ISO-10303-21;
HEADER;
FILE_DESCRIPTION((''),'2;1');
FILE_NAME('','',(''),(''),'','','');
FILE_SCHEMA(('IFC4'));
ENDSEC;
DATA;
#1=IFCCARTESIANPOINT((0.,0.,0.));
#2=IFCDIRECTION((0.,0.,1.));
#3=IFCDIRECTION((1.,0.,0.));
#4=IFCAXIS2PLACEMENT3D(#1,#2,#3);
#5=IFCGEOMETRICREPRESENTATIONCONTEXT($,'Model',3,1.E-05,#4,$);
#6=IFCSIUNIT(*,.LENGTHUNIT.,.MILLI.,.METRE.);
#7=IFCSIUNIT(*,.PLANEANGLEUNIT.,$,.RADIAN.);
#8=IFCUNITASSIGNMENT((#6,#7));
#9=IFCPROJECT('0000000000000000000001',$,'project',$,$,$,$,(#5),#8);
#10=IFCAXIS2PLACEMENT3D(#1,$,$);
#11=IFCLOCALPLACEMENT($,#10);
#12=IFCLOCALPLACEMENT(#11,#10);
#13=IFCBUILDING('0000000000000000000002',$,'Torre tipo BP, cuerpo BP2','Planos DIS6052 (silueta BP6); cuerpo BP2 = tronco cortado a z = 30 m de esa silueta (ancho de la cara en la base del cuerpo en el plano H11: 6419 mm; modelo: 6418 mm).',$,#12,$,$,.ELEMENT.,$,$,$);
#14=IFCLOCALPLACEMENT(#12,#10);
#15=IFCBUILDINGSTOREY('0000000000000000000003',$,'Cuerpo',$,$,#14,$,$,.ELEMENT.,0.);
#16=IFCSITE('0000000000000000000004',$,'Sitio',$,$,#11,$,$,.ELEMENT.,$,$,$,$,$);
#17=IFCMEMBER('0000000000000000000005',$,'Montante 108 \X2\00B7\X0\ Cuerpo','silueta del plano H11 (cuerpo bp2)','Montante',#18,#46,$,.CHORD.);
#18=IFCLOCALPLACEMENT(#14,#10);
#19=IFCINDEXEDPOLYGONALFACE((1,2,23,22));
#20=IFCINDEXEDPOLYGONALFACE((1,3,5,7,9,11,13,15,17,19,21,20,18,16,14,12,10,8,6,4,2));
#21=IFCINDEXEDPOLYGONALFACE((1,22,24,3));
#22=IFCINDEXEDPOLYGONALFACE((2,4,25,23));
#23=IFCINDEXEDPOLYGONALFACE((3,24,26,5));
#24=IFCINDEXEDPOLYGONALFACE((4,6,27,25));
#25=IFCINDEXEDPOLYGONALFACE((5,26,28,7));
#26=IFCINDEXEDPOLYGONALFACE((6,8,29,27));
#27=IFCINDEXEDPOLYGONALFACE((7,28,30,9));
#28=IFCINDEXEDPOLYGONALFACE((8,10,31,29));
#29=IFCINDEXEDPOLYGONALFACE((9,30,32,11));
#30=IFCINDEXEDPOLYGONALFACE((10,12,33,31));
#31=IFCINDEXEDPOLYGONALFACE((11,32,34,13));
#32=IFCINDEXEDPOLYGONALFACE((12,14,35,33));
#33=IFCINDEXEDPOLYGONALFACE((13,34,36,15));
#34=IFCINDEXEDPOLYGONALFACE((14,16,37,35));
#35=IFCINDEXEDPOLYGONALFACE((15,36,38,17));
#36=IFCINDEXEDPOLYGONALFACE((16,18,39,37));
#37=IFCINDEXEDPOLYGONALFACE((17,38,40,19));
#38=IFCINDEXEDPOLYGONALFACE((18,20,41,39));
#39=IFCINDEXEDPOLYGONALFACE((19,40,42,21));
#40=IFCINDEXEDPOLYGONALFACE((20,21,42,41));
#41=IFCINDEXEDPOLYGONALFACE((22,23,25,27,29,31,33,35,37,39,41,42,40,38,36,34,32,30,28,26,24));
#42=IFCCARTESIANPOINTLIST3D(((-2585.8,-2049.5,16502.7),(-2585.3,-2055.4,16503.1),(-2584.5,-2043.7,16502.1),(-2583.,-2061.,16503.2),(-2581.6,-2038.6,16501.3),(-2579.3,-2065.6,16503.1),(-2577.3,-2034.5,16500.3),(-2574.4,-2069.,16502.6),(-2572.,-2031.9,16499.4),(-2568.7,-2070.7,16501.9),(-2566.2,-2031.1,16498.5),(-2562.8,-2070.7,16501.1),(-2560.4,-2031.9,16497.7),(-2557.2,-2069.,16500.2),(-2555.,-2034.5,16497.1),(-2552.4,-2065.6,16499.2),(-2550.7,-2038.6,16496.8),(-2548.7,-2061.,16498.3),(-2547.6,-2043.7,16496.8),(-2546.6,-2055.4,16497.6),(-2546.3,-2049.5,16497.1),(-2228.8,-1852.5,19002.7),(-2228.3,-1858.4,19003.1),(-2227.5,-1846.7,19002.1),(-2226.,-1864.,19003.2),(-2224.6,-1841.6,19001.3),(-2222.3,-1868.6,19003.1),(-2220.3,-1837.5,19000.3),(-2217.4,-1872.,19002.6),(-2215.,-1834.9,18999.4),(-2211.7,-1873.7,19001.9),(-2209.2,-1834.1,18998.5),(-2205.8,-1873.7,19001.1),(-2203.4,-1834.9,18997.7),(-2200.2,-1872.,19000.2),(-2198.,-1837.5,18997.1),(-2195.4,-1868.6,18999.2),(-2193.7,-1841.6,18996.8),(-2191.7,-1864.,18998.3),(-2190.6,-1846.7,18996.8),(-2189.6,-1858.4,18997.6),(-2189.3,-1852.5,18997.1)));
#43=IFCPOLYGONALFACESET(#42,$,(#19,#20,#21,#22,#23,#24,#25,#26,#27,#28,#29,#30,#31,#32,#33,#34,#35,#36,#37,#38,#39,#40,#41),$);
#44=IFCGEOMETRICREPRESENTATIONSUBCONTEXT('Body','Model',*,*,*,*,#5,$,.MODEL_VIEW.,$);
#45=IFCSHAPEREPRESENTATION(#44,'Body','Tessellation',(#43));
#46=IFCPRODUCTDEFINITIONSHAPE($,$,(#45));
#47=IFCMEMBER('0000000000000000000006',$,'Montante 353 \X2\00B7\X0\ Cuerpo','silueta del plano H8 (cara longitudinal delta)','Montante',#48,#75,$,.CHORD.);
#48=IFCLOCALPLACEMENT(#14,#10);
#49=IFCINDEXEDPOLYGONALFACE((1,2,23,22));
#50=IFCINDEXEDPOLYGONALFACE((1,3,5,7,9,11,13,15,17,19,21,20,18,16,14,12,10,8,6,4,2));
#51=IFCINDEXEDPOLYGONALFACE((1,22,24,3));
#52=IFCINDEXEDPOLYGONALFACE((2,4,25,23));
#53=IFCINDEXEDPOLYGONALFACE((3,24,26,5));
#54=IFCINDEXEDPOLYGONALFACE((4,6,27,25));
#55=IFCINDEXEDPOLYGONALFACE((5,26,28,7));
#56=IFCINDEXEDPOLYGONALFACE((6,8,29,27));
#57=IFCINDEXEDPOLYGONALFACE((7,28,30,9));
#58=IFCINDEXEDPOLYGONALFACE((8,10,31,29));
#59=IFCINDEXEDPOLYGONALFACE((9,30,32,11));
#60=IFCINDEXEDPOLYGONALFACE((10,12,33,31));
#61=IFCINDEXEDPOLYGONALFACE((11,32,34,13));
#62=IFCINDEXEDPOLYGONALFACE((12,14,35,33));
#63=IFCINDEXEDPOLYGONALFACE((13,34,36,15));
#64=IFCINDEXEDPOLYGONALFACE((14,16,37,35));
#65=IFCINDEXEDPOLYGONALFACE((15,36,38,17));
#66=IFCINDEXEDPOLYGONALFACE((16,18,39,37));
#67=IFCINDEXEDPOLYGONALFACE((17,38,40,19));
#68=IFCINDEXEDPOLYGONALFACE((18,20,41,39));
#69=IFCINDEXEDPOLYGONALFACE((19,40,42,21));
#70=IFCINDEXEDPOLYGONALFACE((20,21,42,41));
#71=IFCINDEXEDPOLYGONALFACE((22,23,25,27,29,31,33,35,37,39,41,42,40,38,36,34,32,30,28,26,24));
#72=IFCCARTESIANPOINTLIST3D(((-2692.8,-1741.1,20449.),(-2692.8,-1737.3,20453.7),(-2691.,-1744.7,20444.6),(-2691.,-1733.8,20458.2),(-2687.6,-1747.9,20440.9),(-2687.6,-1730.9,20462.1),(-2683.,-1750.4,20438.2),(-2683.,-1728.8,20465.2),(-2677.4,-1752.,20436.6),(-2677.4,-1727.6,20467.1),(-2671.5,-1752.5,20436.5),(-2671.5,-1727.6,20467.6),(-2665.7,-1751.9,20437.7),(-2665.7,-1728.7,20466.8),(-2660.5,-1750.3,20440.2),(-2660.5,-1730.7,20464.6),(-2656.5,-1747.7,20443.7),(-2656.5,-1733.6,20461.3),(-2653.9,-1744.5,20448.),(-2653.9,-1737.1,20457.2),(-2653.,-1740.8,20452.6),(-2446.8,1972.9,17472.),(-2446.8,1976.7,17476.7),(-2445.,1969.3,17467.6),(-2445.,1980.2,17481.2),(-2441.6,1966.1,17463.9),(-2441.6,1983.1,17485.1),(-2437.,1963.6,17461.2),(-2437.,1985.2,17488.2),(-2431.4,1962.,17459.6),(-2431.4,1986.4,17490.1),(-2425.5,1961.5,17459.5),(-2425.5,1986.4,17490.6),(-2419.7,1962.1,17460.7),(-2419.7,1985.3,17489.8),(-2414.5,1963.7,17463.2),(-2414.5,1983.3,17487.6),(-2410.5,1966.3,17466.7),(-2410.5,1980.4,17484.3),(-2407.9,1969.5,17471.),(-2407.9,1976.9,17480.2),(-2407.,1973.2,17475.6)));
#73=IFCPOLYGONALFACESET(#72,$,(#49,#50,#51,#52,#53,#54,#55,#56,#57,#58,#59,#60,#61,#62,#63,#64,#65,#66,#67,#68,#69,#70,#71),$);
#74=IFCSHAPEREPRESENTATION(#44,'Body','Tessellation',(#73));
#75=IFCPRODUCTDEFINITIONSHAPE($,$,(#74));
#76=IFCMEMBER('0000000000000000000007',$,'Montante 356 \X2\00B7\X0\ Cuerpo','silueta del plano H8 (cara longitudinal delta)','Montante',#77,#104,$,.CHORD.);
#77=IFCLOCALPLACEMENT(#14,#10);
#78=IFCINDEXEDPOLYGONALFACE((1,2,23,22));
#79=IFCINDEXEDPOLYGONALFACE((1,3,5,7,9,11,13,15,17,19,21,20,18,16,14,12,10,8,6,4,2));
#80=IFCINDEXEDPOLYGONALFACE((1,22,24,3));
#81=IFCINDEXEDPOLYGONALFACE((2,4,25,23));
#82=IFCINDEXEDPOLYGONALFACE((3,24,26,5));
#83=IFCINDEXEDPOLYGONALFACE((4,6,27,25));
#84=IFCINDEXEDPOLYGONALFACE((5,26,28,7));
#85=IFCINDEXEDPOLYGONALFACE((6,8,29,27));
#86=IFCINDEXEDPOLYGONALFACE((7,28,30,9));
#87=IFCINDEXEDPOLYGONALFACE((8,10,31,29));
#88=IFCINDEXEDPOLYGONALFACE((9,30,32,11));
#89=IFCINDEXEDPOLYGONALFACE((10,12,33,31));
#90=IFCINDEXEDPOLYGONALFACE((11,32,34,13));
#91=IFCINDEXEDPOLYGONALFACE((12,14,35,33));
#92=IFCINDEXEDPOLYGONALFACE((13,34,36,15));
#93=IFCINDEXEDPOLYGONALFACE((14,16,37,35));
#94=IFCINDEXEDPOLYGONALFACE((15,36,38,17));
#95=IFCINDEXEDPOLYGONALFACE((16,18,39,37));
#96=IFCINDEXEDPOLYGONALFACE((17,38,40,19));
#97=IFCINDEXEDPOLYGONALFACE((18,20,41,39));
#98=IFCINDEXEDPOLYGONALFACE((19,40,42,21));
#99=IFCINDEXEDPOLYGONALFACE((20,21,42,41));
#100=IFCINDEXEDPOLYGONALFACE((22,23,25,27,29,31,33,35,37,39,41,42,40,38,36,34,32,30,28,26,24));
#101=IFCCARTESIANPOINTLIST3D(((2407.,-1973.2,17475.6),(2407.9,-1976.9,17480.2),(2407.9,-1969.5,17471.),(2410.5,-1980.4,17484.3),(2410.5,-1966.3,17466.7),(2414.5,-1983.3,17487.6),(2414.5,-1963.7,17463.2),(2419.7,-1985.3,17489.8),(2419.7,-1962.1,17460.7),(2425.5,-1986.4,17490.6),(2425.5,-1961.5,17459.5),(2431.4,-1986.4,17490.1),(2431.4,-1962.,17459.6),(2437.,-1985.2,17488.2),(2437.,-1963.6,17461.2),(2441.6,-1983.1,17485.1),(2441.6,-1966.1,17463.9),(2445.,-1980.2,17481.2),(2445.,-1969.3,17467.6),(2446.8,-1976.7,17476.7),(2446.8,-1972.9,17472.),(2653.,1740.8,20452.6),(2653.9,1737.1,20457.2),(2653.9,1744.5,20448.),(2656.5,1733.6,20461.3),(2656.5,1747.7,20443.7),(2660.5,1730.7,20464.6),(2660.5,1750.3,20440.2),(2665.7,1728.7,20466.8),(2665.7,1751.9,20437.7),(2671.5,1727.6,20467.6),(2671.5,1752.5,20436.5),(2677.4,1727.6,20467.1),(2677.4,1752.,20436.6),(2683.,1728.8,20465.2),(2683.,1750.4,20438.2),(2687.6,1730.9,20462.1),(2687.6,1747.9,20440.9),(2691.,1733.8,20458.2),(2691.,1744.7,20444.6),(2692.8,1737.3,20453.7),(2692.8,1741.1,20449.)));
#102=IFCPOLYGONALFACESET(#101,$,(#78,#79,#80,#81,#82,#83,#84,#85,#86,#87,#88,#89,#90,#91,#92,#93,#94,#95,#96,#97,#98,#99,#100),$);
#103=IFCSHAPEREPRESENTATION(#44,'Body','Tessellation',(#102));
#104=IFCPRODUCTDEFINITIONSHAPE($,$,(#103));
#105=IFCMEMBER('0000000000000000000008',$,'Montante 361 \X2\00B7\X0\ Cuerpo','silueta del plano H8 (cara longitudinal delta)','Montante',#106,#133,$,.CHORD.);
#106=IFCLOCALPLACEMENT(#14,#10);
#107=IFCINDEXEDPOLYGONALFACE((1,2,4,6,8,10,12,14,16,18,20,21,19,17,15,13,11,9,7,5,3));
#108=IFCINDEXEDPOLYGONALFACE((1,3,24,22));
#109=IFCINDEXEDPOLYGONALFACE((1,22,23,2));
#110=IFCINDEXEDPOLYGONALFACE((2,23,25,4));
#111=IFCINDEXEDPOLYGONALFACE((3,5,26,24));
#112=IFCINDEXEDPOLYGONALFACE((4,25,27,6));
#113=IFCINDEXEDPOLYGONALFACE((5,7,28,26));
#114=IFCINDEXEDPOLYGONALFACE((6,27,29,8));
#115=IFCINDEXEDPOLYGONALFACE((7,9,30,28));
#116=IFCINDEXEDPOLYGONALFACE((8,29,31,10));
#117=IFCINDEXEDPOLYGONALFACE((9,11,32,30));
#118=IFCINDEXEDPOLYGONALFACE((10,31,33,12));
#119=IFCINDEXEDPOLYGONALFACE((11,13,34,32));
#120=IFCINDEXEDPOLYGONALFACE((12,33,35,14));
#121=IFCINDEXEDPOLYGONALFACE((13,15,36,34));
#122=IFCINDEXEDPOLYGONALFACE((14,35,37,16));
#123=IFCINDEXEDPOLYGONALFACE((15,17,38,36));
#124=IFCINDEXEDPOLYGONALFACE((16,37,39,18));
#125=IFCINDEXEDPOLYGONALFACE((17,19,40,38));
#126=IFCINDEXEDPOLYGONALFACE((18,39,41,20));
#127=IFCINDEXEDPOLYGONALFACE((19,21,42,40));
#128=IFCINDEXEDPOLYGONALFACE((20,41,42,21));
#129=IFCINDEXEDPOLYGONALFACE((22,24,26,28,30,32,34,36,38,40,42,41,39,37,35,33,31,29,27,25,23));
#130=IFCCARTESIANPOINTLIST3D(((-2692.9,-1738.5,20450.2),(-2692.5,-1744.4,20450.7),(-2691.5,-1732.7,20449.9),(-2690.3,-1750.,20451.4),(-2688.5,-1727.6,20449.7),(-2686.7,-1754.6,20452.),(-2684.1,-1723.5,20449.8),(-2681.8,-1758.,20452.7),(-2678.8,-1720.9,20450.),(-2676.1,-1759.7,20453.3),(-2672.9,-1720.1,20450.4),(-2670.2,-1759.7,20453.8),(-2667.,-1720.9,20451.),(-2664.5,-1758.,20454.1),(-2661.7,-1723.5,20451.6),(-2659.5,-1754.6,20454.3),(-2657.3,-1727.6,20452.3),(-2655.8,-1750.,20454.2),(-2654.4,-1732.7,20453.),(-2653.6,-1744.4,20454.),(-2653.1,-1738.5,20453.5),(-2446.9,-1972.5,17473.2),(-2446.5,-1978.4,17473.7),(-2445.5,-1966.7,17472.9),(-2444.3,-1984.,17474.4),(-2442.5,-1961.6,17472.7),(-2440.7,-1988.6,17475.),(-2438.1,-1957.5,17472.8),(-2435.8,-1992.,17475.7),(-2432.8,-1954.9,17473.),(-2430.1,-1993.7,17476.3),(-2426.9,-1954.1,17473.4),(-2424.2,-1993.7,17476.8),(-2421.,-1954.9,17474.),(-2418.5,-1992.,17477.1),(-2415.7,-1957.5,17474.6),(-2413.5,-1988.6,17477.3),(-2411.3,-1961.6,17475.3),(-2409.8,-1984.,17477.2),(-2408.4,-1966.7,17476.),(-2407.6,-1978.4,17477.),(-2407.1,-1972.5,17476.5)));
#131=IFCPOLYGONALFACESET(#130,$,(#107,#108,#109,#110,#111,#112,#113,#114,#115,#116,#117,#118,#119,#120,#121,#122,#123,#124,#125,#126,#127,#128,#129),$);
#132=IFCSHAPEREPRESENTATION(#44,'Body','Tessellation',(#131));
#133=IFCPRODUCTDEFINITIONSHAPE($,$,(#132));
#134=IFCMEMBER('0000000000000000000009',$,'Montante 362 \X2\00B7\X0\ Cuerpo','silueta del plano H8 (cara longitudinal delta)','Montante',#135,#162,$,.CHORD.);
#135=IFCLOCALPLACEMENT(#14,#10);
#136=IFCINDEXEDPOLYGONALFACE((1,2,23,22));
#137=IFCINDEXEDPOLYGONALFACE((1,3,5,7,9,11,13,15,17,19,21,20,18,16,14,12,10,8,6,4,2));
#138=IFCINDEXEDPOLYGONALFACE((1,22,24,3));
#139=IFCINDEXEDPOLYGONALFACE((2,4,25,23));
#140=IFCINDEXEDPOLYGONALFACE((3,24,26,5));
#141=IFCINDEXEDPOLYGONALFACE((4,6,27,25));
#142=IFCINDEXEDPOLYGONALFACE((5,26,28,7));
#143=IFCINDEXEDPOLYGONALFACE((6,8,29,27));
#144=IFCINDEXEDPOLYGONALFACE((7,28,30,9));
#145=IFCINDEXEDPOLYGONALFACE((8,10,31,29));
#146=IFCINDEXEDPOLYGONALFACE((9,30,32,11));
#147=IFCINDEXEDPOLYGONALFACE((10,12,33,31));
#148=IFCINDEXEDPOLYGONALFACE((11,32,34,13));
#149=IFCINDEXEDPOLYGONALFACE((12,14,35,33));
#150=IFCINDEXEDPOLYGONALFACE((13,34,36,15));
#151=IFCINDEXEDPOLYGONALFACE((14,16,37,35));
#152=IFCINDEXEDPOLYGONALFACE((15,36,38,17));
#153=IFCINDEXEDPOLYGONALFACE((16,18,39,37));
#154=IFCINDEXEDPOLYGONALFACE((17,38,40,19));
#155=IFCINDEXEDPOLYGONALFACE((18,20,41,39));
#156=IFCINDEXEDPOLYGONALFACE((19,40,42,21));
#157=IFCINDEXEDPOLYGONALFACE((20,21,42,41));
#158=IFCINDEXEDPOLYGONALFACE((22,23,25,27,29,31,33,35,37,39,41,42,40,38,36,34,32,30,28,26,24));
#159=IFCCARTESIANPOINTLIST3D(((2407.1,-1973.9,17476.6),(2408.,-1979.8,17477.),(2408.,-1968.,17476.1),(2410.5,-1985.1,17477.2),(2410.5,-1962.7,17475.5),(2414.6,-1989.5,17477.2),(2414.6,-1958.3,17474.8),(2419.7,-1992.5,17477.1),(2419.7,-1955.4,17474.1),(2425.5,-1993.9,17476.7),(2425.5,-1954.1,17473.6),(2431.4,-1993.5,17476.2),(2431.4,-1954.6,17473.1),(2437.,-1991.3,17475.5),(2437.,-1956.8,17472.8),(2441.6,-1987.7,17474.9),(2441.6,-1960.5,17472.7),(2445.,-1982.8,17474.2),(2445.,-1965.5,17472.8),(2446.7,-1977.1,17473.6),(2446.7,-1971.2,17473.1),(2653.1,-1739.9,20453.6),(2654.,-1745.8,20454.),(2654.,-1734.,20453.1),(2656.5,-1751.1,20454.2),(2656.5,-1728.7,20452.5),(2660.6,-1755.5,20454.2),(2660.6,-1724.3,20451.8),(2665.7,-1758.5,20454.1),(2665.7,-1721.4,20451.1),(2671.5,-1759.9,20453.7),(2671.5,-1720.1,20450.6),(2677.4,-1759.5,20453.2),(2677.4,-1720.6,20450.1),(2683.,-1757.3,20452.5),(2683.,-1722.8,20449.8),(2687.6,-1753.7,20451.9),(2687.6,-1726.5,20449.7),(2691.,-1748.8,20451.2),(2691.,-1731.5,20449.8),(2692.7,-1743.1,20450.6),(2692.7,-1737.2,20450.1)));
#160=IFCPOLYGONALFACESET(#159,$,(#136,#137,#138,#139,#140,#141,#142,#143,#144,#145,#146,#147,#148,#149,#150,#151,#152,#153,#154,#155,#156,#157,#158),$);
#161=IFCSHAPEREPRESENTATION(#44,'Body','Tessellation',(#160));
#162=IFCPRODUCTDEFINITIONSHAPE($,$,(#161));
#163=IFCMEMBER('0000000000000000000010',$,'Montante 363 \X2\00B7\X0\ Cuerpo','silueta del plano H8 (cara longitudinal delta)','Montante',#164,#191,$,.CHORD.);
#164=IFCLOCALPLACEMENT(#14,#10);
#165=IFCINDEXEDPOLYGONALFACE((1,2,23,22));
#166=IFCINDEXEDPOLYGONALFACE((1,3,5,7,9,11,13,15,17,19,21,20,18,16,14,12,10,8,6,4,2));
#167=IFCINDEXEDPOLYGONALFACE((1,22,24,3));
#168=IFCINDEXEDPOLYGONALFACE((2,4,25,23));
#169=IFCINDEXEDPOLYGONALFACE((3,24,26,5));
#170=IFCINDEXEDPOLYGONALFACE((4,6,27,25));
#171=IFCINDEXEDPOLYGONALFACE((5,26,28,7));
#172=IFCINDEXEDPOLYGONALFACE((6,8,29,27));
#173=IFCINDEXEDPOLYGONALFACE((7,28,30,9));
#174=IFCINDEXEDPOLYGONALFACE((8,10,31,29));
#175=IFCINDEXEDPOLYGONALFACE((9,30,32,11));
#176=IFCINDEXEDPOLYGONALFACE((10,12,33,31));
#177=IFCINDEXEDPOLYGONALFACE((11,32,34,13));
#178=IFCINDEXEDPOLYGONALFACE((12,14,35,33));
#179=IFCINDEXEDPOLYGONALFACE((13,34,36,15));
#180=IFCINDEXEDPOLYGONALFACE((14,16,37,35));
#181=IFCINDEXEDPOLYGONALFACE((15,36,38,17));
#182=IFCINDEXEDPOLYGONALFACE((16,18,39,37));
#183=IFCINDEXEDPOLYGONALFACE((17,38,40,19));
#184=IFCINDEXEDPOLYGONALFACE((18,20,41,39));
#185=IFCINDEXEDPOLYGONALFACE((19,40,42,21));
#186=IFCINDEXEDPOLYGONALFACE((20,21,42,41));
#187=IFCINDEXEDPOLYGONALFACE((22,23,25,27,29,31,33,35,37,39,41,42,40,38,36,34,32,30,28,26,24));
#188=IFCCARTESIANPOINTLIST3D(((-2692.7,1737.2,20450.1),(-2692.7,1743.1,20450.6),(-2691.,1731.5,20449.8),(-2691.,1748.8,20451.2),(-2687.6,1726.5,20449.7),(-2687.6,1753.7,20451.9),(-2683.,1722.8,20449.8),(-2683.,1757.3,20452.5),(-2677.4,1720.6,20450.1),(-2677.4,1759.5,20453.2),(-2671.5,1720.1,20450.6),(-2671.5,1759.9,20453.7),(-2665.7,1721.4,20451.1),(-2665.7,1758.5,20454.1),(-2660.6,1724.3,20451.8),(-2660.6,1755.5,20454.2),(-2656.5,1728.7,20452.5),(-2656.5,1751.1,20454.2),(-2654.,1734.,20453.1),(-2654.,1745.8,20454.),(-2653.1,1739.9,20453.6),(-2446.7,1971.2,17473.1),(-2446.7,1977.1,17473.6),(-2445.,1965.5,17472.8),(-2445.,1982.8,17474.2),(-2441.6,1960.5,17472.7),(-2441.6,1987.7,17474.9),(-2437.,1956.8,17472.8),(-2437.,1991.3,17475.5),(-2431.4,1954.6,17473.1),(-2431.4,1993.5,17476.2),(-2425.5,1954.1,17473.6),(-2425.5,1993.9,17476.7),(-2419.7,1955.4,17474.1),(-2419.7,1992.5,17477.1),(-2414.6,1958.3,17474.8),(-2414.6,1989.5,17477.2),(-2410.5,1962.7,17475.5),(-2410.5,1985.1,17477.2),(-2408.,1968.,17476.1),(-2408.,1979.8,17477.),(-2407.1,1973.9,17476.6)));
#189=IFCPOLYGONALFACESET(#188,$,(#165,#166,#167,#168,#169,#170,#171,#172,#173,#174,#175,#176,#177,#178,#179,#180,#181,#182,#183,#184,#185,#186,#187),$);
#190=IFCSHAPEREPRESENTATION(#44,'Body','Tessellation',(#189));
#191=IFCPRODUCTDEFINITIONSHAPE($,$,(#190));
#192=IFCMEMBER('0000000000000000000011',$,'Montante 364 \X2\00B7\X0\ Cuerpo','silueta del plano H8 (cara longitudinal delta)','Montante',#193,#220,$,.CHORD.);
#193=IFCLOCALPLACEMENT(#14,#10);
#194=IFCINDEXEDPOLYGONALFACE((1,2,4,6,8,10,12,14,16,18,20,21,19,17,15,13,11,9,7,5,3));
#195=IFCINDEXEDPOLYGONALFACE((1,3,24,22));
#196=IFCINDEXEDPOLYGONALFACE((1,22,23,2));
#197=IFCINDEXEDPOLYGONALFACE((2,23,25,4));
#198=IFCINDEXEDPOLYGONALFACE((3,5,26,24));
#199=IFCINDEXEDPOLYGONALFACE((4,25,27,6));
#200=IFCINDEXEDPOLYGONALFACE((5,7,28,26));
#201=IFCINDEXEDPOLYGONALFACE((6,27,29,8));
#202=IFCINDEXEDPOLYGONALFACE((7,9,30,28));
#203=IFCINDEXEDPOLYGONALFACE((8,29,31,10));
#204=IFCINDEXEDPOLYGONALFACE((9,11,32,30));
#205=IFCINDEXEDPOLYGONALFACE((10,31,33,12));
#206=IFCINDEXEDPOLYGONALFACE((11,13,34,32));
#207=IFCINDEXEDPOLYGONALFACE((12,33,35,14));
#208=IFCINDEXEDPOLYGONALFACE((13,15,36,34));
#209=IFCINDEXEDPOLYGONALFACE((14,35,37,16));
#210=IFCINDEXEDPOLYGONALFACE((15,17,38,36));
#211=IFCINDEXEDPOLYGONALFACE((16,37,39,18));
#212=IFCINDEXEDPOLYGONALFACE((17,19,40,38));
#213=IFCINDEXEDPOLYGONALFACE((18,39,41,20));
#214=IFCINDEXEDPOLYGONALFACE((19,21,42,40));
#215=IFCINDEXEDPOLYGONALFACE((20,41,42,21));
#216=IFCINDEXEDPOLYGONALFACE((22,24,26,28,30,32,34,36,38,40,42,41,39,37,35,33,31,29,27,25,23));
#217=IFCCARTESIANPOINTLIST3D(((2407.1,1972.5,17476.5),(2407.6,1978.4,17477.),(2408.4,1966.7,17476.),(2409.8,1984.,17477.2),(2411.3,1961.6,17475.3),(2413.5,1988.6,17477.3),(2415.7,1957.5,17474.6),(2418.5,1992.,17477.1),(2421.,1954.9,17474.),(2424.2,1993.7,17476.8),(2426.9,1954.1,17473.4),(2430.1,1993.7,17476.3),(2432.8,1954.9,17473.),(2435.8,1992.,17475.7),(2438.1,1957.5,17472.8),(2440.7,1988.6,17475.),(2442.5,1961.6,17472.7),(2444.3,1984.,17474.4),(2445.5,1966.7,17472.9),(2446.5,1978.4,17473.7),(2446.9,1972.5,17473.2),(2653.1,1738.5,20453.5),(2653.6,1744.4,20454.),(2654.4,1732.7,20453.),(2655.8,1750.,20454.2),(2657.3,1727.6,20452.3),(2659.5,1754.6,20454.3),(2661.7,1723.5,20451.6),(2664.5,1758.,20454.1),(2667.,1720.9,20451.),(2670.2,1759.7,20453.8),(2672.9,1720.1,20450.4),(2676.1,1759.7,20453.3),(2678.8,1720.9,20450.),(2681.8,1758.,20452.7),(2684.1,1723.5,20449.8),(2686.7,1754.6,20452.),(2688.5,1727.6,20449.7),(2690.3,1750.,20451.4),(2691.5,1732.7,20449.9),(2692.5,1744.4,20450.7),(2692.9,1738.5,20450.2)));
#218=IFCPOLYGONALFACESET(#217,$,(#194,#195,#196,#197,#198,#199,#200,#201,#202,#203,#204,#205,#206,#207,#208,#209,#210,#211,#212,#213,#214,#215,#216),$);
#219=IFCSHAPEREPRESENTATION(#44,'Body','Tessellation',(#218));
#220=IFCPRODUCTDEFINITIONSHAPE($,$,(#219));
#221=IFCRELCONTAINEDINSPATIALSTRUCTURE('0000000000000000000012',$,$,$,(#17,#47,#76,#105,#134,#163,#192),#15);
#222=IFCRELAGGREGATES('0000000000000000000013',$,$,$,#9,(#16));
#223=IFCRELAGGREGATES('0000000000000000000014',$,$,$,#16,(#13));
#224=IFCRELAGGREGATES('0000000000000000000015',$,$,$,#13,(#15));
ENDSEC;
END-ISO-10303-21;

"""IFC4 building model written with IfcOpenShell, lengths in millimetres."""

from ifc_helpers import new_model, si_unit, frame, origin, origin_with_axes, place, context, subcontext, project, spatial, circle, extrude, element, save


model = new_model("IFC4")

# Units and contexts
model_context = context("Model", 3, precision=1e-05, world=origin_with_axes())
body_context = subcontext(model_context, "Body", "Model", "MODEL_VIEW")
ifc_project = project(units=[si_unit("LENGTHUNIT", "METRE", prefix="MILLI"), si_unit("PLANEANGLEUNIT", "RADIAN")], contexts=[model_context])

# Site, building, storey
site_placement = place(None, origin())
site = spatial("IfcSite", under=ifc_project, at=site_placement, Name="Sitio", CompositionType="ELEMENT")
building_placement = place(site_placement, origin())
building = spatial("IfcBuilding", under=site, at=building_placement, Name="Torre tipo BP, cuerpo BP2", Description="Planos DIS6052 (silueta BP6); cuerpo BP2 = tronco cortado a z = 30 m de esa silueta (ancho de la cara en la base del cuerpo en el plano H11: 6419 mm; modelo: 6418 mm).", CompositionType="ELEMENT")
storey_placement = place(building_placement, origin())
storey = spatial("IfcBuildingStorey", under=building, at=storey_placement, Name="Cuerpo", CompositionType="ELEMENT", Elevation=0.0)

# Members
for number, where, z_axis, x_axis, name in (
    (1, (-2209.0, -1854.0, 19000.0), (-0.140938, -0.077772, -0.986959), (-0.010994, 0.996971, -0.076991), "Montante 108 · Cuerpo"),
):
    element("IfcMember", number, at=place(storey_placement, frame(where, z_axis=z_axis, x_axis=x_axis)), inside=storey, Name=name, Description="silueta del plano H11 (cuerpo bp2)", ObjectType="Montante", PredefinedType="CHORD", context=body_context, shape_type="SweptSolid", body=[
        extrude(circle(Radius=20.0), None, (0.0, 0.0, 1.0), 2533.0),
    ])
for number, where, z_axis, x_axis, name in (
    (2, (-2673.0, -1740.0, 20452.0), (0.051613, 0.779234, -0.624604), (0.998667, -0.040272, 0.032281), "Montante 353 · Cuerpo"),
    (3, (2673.0, 1740.0, 20452.0), (-0.051613, -0.779234, -0.624604), (-0.998667, 0.040272, 0.032281), "Montante 356 · Cuerpo"),
):
    element("IfcMember", number, at=place(storey_placement, frame(where, z_axis=z_axis, x_axis=x_axis)), inside=storey, Name=name, Description="silueta del plano H8 (cara longitudinal delta)", ObjectType="Montante", PredefinedType="CHORD", context=body_context, shape_type="SweptSolid", body=[
        extrude(circle(Radius=20.0), None, (0.0, 0.0, 1.0), 4766.2),
    ])
for number, where, z_axis, x_axis, name in (
    (4, (-2673.0, -1740.0, 20452.0), (0.082101, -0.078096, -0.993559), (0.006431, 0.996946, -0.077831), "Montante 361 · Cuerpo"),
    (5, (2673.0, -1740.0, 20452.0), (-0.082101, -0.078096, -0.993559), (-0.996624, 0.006434, 0.081849), "Montante 362 · Cuerpo"),
    (6, (-2673.0, 1740.0, 20452.0), (0.082101, 0.078096, -0.993559), (0.996624, -0.006434, 0.081849), "Montante 363 · Cuerpo"),
    (7, (2673.0, 1740.0, 20452.0), (-0.082101, 0.078096, -0.993559), (-0.006431, -0.996946, -0.077831), "Montante 364 · Cuerpo"),
):
    element("IfcMember", number, at=place(storey_placement, frame(where, z_axis=z_axis, x_axis=x_axis)), inside=storey, Name=name, Description="silueta del plano H8 (cara longitudinal delta)", ObjectType="Montante", PredefinedType="CHORD", context=body_context, shape_type="SweptSolid", body=[
        extrude(circle(Radius=20.0), None, (0.0, 0.0, 1.0), 2996.3),
    ])

save(model, "model.ifc")
